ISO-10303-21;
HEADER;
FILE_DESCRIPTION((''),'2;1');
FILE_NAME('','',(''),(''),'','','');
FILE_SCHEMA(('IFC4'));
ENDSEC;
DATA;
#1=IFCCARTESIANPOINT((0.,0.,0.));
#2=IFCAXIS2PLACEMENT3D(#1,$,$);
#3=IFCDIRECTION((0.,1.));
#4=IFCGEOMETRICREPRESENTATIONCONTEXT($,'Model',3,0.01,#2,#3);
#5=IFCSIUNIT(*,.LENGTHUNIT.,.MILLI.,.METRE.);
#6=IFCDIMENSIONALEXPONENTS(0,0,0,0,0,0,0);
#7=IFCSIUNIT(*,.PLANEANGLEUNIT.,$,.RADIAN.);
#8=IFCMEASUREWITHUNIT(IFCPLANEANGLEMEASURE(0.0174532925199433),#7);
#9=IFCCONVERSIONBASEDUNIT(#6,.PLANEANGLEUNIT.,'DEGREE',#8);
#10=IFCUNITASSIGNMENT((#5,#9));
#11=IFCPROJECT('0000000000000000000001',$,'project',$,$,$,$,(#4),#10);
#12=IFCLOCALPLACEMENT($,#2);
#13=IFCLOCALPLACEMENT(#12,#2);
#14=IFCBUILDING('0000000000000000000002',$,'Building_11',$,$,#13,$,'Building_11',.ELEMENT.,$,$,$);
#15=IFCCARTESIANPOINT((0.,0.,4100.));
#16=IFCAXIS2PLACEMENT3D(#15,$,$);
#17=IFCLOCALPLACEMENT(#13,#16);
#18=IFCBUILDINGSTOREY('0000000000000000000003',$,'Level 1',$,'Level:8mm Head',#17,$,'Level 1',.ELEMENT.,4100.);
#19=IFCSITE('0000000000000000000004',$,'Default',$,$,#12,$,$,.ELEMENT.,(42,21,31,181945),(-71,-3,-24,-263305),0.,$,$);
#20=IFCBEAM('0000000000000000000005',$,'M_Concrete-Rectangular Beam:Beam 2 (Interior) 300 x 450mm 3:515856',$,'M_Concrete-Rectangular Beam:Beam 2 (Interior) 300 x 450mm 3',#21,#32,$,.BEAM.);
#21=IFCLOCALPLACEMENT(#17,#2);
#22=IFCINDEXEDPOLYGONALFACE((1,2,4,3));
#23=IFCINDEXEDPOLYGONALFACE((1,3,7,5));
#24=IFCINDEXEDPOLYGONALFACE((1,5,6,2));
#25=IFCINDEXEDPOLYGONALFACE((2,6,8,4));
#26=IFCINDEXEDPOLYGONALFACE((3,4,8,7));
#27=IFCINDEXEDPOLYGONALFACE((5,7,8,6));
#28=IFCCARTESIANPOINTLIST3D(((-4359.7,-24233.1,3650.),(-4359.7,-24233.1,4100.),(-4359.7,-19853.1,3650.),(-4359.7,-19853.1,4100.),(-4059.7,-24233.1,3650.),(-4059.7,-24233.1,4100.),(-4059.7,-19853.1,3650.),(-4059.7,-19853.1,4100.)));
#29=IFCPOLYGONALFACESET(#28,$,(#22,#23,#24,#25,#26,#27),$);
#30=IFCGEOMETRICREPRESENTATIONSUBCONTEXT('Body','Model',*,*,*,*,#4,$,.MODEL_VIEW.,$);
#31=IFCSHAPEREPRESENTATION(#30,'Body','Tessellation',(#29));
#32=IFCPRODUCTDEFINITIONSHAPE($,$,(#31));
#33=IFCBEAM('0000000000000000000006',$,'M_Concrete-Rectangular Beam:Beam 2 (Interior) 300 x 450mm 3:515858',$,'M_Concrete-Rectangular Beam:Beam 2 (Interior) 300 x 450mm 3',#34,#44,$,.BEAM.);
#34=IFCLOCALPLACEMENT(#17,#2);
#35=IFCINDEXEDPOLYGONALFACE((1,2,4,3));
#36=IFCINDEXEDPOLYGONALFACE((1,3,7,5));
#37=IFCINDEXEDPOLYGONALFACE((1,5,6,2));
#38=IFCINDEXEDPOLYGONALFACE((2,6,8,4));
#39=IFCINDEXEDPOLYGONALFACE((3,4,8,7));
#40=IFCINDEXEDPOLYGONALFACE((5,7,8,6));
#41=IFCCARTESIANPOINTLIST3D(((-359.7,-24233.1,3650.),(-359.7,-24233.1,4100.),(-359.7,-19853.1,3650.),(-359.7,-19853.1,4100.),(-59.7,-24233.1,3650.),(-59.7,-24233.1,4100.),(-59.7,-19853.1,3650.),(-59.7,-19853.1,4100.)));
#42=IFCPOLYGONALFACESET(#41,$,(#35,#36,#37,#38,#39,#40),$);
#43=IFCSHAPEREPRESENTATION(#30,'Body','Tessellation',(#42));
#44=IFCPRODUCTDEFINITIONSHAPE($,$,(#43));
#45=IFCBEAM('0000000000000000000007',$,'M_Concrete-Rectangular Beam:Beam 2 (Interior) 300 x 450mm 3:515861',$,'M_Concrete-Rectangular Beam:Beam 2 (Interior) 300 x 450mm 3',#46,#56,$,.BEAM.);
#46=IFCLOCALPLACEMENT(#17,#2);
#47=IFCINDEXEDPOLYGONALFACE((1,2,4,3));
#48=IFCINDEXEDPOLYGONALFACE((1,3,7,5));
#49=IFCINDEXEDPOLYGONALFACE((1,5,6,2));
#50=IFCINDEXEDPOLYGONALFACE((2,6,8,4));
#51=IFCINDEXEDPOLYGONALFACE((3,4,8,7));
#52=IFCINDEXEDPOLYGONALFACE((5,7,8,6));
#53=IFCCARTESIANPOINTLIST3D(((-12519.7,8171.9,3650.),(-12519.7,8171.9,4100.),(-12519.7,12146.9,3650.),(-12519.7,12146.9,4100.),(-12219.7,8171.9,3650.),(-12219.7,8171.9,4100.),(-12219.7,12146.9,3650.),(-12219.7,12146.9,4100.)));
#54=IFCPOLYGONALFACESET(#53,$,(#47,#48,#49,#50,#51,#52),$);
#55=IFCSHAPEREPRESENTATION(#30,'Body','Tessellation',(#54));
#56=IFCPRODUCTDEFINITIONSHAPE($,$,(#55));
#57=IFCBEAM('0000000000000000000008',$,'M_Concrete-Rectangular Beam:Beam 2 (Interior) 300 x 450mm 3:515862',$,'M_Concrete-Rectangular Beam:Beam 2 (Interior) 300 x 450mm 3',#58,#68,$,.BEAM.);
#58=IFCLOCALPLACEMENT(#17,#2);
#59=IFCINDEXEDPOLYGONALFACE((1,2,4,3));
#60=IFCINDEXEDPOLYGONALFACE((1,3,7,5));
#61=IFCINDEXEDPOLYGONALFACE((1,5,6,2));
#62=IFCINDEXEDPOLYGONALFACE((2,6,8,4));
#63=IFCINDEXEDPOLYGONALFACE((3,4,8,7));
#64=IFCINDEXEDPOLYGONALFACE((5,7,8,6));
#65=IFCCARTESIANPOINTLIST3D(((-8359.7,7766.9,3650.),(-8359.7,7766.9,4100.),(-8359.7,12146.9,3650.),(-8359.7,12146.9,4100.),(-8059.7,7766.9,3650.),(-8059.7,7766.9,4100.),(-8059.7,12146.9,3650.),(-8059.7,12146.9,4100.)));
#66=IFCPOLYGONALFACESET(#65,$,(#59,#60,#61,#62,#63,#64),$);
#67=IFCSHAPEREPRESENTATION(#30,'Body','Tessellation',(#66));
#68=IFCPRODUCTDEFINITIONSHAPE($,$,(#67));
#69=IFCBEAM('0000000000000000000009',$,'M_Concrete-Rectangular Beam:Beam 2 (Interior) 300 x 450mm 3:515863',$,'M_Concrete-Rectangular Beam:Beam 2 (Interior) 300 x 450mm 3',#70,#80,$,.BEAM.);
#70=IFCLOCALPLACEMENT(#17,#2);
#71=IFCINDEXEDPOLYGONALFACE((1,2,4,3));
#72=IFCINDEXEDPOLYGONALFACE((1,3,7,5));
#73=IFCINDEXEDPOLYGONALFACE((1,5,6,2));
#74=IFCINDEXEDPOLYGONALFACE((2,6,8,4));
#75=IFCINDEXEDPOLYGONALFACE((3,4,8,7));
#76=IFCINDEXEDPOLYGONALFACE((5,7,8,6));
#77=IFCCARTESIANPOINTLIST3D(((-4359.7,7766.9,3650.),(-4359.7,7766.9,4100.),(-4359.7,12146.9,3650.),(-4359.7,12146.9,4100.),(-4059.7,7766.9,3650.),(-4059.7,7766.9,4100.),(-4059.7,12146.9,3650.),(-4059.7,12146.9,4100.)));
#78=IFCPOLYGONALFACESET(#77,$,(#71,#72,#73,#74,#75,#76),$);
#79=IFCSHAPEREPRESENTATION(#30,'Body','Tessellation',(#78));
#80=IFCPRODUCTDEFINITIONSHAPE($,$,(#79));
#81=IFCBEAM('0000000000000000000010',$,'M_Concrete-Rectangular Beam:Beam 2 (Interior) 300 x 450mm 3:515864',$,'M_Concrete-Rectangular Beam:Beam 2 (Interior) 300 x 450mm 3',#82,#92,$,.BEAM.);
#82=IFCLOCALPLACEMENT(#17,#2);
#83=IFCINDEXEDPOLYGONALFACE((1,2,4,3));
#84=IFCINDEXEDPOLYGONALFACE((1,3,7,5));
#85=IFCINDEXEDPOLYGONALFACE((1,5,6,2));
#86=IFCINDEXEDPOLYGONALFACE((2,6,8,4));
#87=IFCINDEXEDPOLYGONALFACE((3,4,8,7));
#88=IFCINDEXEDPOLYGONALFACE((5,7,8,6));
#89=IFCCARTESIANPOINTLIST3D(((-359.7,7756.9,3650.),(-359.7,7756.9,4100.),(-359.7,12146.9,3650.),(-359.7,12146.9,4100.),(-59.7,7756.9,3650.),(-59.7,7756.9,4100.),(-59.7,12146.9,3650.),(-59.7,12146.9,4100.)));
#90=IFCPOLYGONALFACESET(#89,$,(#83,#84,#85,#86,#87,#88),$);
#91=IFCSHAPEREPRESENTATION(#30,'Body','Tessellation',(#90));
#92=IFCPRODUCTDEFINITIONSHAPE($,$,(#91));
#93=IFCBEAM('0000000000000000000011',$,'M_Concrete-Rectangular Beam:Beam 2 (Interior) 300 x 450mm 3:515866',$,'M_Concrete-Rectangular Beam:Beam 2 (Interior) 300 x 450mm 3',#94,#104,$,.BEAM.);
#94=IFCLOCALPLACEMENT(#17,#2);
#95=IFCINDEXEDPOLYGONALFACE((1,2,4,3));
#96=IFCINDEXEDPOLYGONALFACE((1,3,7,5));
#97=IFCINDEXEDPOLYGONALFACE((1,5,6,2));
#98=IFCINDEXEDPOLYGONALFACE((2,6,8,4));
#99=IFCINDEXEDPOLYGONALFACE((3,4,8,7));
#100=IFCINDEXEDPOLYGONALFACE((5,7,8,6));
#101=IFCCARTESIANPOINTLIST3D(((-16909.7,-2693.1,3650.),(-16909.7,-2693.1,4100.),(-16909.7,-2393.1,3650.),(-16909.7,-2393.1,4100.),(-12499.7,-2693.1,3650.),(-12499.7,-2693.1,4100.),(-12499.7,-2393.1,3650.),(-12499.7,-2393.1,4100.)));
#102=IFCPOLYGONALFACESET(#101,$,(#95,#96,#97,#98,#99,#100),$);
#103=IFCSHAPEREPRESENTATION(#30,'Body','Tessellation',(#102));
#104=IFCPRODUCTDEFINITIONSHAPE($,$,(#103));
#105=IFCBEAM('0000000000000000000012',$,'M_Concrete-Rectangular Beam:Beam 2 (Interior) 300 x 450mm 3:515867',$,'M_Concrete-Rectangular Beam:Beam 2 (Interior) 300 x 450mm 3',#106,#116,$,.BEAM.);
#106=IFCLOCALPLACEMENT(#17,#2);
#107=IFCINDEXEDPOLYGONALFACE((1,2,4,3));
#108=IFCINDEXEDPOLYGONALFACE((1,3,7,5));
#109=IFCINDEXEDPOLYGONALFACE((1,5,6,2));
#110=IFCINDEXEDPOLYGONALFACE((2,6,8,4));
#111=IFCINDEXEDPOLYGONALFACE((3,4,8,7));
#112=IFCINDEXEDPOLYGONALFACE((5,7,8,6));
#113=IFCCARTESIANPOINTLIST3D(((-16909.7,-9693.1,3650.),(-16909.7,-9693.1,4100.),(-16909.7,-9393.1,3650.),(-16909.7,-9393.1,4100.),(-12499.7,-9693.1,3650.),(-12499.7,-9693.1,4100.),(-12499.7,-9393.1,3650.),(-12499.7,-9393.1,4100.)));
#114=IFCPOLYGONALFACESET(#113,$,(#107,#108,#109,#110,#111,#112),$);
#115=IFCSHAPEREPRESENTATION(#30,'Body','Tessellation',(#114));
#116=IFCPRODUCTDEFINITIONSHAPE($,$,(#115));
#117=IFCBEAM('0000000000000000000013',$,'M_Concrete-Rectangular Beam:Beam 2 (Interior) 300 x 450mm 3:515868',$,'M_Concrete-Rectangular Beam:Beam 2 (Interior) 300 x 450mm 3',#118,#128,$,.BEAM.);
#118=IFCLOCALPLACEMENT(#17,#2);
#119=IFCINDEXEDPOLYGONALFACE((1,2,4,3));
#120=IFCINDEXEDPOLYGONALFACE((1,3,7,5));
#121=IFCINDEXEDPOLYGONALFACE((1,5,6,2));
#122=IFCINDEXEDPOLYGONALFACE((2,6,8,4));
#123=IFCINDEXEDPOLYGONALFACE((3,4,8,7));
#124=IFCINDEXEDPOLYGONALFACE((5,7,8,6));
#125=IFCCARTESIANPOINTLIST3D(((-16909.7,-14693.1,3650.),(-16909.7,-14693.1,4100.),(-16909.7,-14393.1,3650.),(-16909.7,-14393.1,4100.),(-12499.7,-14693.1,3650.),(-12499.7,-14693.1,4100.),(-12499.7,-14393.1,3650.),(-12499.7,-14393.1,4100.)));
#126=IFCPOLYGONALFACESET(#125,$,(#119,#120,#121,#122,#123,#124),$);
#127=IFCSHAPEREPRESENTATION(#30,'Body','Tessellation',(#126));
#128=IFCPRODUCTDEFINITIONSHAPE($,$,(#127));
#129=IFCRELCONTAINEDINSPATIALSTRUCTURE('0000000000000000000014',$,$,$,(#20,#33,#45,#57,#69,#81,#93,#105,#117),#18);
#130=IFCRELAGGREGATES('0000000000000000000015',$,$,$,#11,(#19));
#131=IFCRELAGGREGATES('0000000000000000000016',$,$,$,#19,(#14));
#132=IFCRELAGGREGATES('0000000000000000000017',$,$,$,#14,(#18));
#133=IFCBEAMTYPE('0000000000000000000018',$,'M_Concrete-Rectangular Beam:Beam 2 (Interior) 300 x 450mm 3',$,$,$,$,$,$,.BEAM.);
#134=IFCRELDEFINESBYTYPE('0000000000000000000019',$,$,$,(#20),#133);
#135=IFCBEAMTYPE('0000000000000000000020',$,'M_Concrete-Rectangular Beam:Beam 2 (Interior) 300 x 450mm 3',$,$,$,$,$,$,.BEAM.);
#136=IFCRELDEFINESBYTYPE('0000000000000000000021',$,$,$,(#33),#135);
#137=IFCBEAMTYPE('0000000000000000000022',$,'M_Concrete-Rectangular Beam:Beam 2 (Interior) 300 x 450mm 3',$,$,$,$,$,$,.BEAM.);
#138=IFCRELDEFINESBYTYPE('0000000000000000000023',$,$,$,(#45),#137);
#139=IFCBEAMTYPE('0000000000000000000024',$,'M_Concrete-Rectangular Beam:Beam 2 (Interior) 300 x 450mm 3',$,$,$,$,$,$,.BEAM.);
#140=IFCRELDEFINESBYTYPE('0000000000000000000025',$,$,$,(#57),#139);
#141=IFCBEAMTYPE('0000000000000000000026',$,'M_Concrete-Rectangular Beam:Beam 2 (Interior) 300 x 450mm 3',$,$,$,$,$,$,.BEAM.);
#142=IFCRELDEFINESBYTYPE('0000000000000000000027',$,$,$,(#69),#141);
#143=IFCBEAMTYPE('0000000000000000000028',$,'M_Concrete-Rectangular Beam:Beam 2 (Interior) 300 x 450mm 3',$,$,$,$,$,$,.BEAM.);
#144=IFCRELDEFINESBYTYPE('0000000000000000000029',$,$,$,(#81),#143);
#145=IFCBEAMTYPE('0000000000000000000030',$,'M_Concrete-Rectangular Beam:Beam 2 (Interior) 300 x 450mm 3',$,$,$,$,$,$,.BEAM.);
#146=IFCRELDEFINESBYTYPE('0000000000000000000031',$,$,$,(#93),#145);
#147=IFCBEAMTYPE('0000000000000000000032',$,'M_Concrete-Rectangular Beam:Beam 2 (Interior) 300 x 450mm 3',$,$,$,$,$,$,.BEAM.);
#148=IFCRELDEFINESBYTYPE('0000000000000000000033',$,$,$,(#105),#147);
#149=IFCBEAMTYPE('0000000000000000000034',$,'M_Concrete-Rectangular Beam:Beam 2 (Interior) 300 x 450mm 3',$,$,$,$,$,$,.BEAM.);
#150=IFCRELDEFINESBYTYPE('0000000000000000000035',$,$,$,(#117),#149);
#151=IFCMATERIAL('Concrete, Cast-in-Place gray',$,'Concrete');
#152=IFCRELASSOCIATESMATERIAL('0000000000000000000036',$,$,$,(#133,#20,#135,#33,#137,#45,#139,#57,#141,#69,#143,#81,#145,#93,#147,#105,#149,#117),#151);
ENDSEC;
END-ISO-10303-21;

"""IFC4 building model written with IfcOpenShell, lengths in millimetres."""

from ifc_helpers import new_model, entity, si_unit, converted_unit, direction, frame, origin, place, context, subcontext, project, spatial, indexed_curve, outline, extrude, source, transform, mapped, material, type_object, type_shapes, element, save


model = new_model("IFC4")

# Units and contexts
model_context = context("Model", 3, precision=0.01, world=origin(), true_north=direction((0.0, 1.0)))
body_context = subcontext(model_context, "Body", "Model", "MODEL_VIEW")
ifc_project = project(units=[si_unit("LENGTHUNIT", "METRE", prefix="MILLI"), converted_unit("PLANEANGLEUNIT", "DEGREE", entity("IfcPlaneAngleMeasure", 0.0174532925199433), si_unit("PLANEANGLEUNIT", "RADIAN"), dimensions=[0, 0, 0, 0, 0, 0, 0])], contexts=[model_context])

# Site, building, storey
site_placement = place(None, origin())
site = spatial("IfcSite", under=ifc_project, at=site_placement, Name="Default", CompositionType="ELEMENT", RefLatitude=(42, 21, 31, 181945), RefLongitude=(-71, -3, -24, -263305), RefElevation=0.0)
building_placement = place(site_placement, origin())
building = spatial("IfcBuilding", under=site, at=building_placement, Name="Building_11", LongName="Building_11", CompositionType="ELEMENT")
storey_placement = place(building_placement, frame((0.0, 0.0, 4100.0)))
storey = spatial("IfcBuildingStorey", under=building, at=storey_placement, Name="Level 1", ObjectType="Level:8mm Head", LongName="Level 1", CompositionType="ELEMENT", Elevation=4100.0)

# Beams
ifc_material_1 = material(Name="Concrete, Cast-in-Place gray", Category="Concrete")
beam_type_1 = type_object("IfcBeamType", Name="M_Concrete-Rectangular Beam:Beam 2 (Interior) 300 x 450mm 3", PredefinedType="BEAM", material=ifc_material_1)
shared_shape_1 = source(origin(), body_context, "Body", "SweptSolid", [
    extrude(outline(indexed_curve([(-150.0, -225.0), (150.0, -225.0), (150.0, 225.0), (-150.0, 225.0), (-150.0, -225.0)], self_intersect=False)), frame((-4209.7, -19853.1, 7975.0), z_axis=(0.0, -1.0, 0.0), x_axis=(-1.0, 0.0, 0.0)), (0.0, 0.0, 1.0), 4380.0),
])
type_shapes(beam_type_1, [shared_shape_1])
beam_1_placement = place(storey_placement, frame((0.0, 0.0, -4100.0)))
element("IfcBeam", 1, at=beam_1_placement, inside=storey, type_object=beam_type_1, material=ifc_material_1, Name="M_Concrete-Rectangular Beam:Beam 2 (Interior) 300 x 450mm 3:515856", ObjectType="M_Concrete-Rectangular Beam:Beam 2 (Interior) 300 x 450mm 3", PredefinedType="BEAM", context=body_context, shape_type="MappedRepresentation", body=[
    mapped(shared_shape_1, transform((0.0, 0.0, 0.0), scale=1.0)),
])
beam_type_2 = type_object("IfcBeamType", Name="M_Concrete-Rectangular Beam:Beam 2 (Interior) 300 x 450mm 3", PredefinedType="BEAM", material=ifc_material_1)
shared_shape_2 = source(origin(), body_context, "Body", "SweptSolid", [
    extrude(outline(indexed_curve([(-150.0, -225.0), (150.0, -225.0), (150.0, 225.0), (-150.0, 225.0), (-150.0, -225.0)], self_intersect=False)), frame((-209.7, -19853.1, 7975.0), z_axis=(0.0, -1.0, 0.0), x_axis=(-1.0, 0.0, 0.0)), (0.0, 0.0, 1.0), 4380.0),
])
type_shapes(beam_type_2, [shared_shape_2])
beam_2_placement = place(storey_placement, frame((0.0, 0.0, -4100.0)))
element("IfcBeam", 2, at=beam_2_placement, inside=storey, type_object=beam_type_2, material=ifc_material_1, Name="M_Concrete-Rectangular Beam:Beam 2 (Interior) 300 x 450mm 3:515858", ObjectType="M_Concrete-Rectangular Beam:Beam 2 (Interior) 300 x 450mm 3", PredefinedType="BEAM", context=body_context, shape_type="MappedRepresentation", body=[
    mapped(shared_shape_2, transform((0.0, 0.0, 0.0), scale=1.0)),
])
beam_type_3 = type_object("IfcBeamType", Name="M_Concrete-Rectangular Beam:Beam 2 (Interior) 300 x 450mm 3", PredefinedType="BEAM", material=ifc_material_1)
shared_shape_3 = source(origin(), body_context, "Body", "SweptSolid", [
    extrude(outline(indexed_curve([(-150.0, -225.0), (150.0, -225.0), (150.0, 225.0), (-150.0, 225.0), (-150.0, -225.0)], self_intersect=False)), frame((-12369.7, 12146.9, 7975.0), z_axis=(0.0, -1.0, 0.0), x_axis=(-1.0, 0.0, 0.0)), (0.0, 0.0, 1.0), 3975.0),
])
type_shapes(beam_type_3, [shared_shape_3])
beam_3_placement = place(storey_placement, frame((0.0, 0.0, -4100.0)))
element("IfcBeam", 3, at=beam_3_placement, inside=storey, type_object=beam_type_3, material=ifc_material_1, Name="M_Concrete-Rectangular Beam:Beam 2 (Interior) 300 x 450mm 3:515861", ObjectType="M_Concrete-Rectangular Beam:Beam 2 (Interior) 300 x 450mm 3", PredefinedType="BEAM", context=body_context, shape_type="MappedRepresentation", body=[
    mapped(shared_shape_3, transform((0.0, 0.0, 0.0), scale=1.0)),
])
beam_type_4 = type_object("IfcBeamType", Name="M_Concrete-Rectangular Beam:Beam 2 (Interior) 300 x 450mm 3", PredefinedType="BEAM", material=ifc_material_1)
shared_shape_4 = source(origin(), body_context, "Body", "SweptSolid", [
    extrude(outline(indexed_curve([(-150.0, -225.0), (150.0, -225.0), (150.0, 225.0), (-150.0, 225.0), (-150.0, -225.0)], self_intersect=False)), frame((-8209.7, 12146.9, 7975.0), z_axis=(0.0, -1.0, 0.0), x_axis=(-1.0, 0.0, 0.0)), (0.0, 0.0, 1.0), 4380.0),
])
type_shapes(beam_type_4, [shared_shape_4])
beam_4_placement = place(storey_placement, frame((0.0, 0.0, -4100.0)))
element("IfcBeam", 4, at=beam_4_placement, inside=storey, type_object=beam_type_4, material=ifc_material_1, Name="M_Concrete-Rectangular Beam:Beam 2 (Interior) 300 x 450mm 3:515862", ObjectType="M_Concrete-Rectangular Beam:Beam 2 (Interior) 300 x 450mm 3", PredefinedType="BEAM", context=body_context, shape_type="MappedRepresentation", body=[
    mapped(shared_shape_4, transform((0.0, 0.0, 0.0), scale=1.0)),
])
beam_type_5 = type_object("IfcBeamType", Name="M_Concrete-Rectangular Beam:Beam 2 (Interior) 300 x 450mm 3", PredefinedType="BEAM", material=ifc_material_1)
shared_shape_5 = source(origin(), body_context, "Body", "SweptSolid", [
    extrude(outline(indexed_curve([(-150.0, -225.0), (150.0, -225.0), (150.0, 225.0), (-150.0, 225.0), (-150.0, -225.0)], self_intersect=False)), frame((-4209.7, 12146.9, 7975.0), z_axis=(0.0, -1.0, 0.0), x_axis=(-1.0, 0.0, 0.0)), (0.0, 0.0, 1.0), 4380.0),
])
type_shapes(beam_type_5, [shared_shape_5])
beam_5_placement = place(storey_placement, frame((0.0, 0.0, -4100.0)))
element("IfcBeam", 5, at=beam_5_placement, inside=storey, type_object=beam_type_5, material=ifc_material_1, Name="M_Concrete-Rectangular Beam:Beam 2 (Interior) 300 x 450mm 3:515863", ObjectType="M_Concrete-Rectangular Beam:Beam 2 (Interior) 300 x 450mm 3", PredefinedType="BEAM", context=body_context, shape_type="MappedRepresentation", body=[
    mapped(shared_shape_5, transform((0.0, 0.0, 0.0), scale=1.0)),
])
beam_type_6 = type_object("IfcBeamType", Name="M_Concrete-Rectangular Beam:Beam 2 (Interior) 300 x 450mm 3", PredefinedType="BEAM", material=ifc_material_1)
shared_shape_6 = source(origin(), body_context, "Body", "SweptSolid", [
    extrude(outline(indexed_curve([(-150.0, -225.0), (150.0, -225.0), (150.0, 225.0), (-150.0, 225.0), (-150.0, -225.0)], self_intersect=False)), frame((-209.7, 12146.9, 7975.0), z_axis=(0.0, -1.0, 0.0), x_axis=(-1.0, 0.0, 0.0)), (0.0, 0.0, 1.0), 4390.0),
])
type_shapes(beam_type_6, [shared_shape_6])
beam_6_placement = place(storey_placement, frame((0.0, 0.0, -4100.0)))
element("IfcBeam", 6, at=beam_6_placement, inside=storey, type_object=beam_type_6, material=ifc_material_1, Name="M_Concrete-Rectangular Beam:Beam 2 (Interior) 300 x 450mm 3:515864", ObjectType="M_Concrete-Rectangular Beam:Beam 2 (Interior) 300 x 450mm 3", PredefinedType="BEAM", context=body_context, shape_type="MappedRepresentation", body=[
    mapped(shared_shape_6, transform((0.0, 0.0, 0.0), scale=1.0)),
])
beam_type_7 = type_object("IfcBeamType", Name="M_Concrete-Rectangular Beam:Beam 2 (Interior) 300 x 450mm 3", PredefinedType="BEAM", material=ifc_material_1)
shared_shape_7 = source(origin(), body_context, "Body", "SweptSolid", [
    extrude(outline(indexed_curve([(-225.0, -150.0), (225.0, -150.0), (225.0, 150.0), (-225.0, 150.0), (-225.0, -150.0)], self_intersect=False)), frame((-16909.7, -2543.1, 7975.0), z_axis=(1.0, 0.0, 0.0), x_axis=(0.0, 0.0, -1.0)), (0.0, 0.0, 1.0), 4410.0),
])
type_shapes(beam_type_7, [shared_shape_7])
beam_7_placement = place(storey_placement, frame((0.0, 0.0, -4100.0)))
element("IfcBeam", 7, at=beam_7_placement, inside=storey, type_object=beam_type_7, material=ifc_material_1, Name="M_Concrete-Rectangular Beam:Beam 2 (Interior) 300 x 450mm 3:515866", ObjectType="M_Concrete-Rectangular Beam:Beam 2 (Interior) 300 x 450mm 3", PredefinedType="BEAM", context=body_context, shape_type="MappedRepresentation", body=[
    mapped(shared_shape_7, transform((0.0, 0.0, 0.0), scale=1.0)),
])
beam_type_8 = type_object("IfcBeamType", Name="M_Concrete-Rectangular Beam:Beam 2 (Interior) 300 x 450mm 3", PredefinedType="BEAM", material=ifc_material_1)
shared_shape_8 = source(origin(), body_context, "Body", "SweptSolid", [
    extrude(outline(indexed_curve([(-225.0, -150.0), (225.0, -150.0), (225.0, 150.0), (-225.0, 150.0), (-225.0, -150.0)], self_intersect=False)), frame((-16909.7, -9543.1, 7975.0), z_axis=(1.0, 0.0, 0.0), x_axis=(0.0, 0.0, -1.0)), (0.0, 0.0, 1.0), 4410.0),
])
type_shapes(beam_type_8, [shared_shape_8])
beam_8_placement = place(storey_placement, frame((0.0, 0.0, -4100.0)))
element("IfcBeam", 8, at=beam_8_placement, inside=storey, type_object=beam_type_8, material=ifc_material_1, Name="M_Concrete-Rectangular Beam:Beam 2 (Interior) 300 x 450mm 3:515867", ObjectType="M_Concrete-Rectangular Beam:Beam 2 (Interior) 300 x 450mm 3", PredefinedType="BEAM", context=body_context, shape_type="MappedRepresentation", body=[
    mapped(shared_shape_8, transform((0.0, 0.0, 0.0), scale=1.0)),
])
beam_type_9 = type_object("IfcBeamType", Name="M_Concrete-Rectangular Beam:Beam 2 (Interior) 300 x 450mm 3", PredefinedType="BEAM", material=ifc_material_1)
shared_shape_9 = source(origin(), body_context, "Body", "SweptSolid", [
    extrude(outline(indexed_curve([(-225.0, -150.0), (225.0, -150.0), (225.0, 150.0), (-225.0, 150.0), (-225.0, -150.0)], self_intersect=False)), frame((-16909.7, -14543.1, 7975.0), z_axis=(1.0, 0.0, 0.0), x_axis=(0.0, 0.0, -1.0)), (0.0, 0.0, 1.0), 4410.0),
])
type_shapes(beam_type_9, [shared_shape_9])
beam_9_placement = place(storey_placement, frame((0.0, 0.0, -4100.0)))
element("IfcBeam", 9, at=beam_9_placement, inside=storey, type_object=beam_type_9, material=ifc_material_1, Name="M_Concrete-Rectangular Beam:Beam 2 (Interior) 300 x 450mm 3:515868", ObjectType="M_Concrete-Rectangular Beam:Beam 2 (Interior) 300 x 450mm 3", PredefinedType="BEAM", context=body_context, shape_type="MappedRepresentation", body=[
    mapped(shared_shape_9, transform((0.0, 0.0, 0.0), scale=1.0)),
])

save(model, "model.ifc")
